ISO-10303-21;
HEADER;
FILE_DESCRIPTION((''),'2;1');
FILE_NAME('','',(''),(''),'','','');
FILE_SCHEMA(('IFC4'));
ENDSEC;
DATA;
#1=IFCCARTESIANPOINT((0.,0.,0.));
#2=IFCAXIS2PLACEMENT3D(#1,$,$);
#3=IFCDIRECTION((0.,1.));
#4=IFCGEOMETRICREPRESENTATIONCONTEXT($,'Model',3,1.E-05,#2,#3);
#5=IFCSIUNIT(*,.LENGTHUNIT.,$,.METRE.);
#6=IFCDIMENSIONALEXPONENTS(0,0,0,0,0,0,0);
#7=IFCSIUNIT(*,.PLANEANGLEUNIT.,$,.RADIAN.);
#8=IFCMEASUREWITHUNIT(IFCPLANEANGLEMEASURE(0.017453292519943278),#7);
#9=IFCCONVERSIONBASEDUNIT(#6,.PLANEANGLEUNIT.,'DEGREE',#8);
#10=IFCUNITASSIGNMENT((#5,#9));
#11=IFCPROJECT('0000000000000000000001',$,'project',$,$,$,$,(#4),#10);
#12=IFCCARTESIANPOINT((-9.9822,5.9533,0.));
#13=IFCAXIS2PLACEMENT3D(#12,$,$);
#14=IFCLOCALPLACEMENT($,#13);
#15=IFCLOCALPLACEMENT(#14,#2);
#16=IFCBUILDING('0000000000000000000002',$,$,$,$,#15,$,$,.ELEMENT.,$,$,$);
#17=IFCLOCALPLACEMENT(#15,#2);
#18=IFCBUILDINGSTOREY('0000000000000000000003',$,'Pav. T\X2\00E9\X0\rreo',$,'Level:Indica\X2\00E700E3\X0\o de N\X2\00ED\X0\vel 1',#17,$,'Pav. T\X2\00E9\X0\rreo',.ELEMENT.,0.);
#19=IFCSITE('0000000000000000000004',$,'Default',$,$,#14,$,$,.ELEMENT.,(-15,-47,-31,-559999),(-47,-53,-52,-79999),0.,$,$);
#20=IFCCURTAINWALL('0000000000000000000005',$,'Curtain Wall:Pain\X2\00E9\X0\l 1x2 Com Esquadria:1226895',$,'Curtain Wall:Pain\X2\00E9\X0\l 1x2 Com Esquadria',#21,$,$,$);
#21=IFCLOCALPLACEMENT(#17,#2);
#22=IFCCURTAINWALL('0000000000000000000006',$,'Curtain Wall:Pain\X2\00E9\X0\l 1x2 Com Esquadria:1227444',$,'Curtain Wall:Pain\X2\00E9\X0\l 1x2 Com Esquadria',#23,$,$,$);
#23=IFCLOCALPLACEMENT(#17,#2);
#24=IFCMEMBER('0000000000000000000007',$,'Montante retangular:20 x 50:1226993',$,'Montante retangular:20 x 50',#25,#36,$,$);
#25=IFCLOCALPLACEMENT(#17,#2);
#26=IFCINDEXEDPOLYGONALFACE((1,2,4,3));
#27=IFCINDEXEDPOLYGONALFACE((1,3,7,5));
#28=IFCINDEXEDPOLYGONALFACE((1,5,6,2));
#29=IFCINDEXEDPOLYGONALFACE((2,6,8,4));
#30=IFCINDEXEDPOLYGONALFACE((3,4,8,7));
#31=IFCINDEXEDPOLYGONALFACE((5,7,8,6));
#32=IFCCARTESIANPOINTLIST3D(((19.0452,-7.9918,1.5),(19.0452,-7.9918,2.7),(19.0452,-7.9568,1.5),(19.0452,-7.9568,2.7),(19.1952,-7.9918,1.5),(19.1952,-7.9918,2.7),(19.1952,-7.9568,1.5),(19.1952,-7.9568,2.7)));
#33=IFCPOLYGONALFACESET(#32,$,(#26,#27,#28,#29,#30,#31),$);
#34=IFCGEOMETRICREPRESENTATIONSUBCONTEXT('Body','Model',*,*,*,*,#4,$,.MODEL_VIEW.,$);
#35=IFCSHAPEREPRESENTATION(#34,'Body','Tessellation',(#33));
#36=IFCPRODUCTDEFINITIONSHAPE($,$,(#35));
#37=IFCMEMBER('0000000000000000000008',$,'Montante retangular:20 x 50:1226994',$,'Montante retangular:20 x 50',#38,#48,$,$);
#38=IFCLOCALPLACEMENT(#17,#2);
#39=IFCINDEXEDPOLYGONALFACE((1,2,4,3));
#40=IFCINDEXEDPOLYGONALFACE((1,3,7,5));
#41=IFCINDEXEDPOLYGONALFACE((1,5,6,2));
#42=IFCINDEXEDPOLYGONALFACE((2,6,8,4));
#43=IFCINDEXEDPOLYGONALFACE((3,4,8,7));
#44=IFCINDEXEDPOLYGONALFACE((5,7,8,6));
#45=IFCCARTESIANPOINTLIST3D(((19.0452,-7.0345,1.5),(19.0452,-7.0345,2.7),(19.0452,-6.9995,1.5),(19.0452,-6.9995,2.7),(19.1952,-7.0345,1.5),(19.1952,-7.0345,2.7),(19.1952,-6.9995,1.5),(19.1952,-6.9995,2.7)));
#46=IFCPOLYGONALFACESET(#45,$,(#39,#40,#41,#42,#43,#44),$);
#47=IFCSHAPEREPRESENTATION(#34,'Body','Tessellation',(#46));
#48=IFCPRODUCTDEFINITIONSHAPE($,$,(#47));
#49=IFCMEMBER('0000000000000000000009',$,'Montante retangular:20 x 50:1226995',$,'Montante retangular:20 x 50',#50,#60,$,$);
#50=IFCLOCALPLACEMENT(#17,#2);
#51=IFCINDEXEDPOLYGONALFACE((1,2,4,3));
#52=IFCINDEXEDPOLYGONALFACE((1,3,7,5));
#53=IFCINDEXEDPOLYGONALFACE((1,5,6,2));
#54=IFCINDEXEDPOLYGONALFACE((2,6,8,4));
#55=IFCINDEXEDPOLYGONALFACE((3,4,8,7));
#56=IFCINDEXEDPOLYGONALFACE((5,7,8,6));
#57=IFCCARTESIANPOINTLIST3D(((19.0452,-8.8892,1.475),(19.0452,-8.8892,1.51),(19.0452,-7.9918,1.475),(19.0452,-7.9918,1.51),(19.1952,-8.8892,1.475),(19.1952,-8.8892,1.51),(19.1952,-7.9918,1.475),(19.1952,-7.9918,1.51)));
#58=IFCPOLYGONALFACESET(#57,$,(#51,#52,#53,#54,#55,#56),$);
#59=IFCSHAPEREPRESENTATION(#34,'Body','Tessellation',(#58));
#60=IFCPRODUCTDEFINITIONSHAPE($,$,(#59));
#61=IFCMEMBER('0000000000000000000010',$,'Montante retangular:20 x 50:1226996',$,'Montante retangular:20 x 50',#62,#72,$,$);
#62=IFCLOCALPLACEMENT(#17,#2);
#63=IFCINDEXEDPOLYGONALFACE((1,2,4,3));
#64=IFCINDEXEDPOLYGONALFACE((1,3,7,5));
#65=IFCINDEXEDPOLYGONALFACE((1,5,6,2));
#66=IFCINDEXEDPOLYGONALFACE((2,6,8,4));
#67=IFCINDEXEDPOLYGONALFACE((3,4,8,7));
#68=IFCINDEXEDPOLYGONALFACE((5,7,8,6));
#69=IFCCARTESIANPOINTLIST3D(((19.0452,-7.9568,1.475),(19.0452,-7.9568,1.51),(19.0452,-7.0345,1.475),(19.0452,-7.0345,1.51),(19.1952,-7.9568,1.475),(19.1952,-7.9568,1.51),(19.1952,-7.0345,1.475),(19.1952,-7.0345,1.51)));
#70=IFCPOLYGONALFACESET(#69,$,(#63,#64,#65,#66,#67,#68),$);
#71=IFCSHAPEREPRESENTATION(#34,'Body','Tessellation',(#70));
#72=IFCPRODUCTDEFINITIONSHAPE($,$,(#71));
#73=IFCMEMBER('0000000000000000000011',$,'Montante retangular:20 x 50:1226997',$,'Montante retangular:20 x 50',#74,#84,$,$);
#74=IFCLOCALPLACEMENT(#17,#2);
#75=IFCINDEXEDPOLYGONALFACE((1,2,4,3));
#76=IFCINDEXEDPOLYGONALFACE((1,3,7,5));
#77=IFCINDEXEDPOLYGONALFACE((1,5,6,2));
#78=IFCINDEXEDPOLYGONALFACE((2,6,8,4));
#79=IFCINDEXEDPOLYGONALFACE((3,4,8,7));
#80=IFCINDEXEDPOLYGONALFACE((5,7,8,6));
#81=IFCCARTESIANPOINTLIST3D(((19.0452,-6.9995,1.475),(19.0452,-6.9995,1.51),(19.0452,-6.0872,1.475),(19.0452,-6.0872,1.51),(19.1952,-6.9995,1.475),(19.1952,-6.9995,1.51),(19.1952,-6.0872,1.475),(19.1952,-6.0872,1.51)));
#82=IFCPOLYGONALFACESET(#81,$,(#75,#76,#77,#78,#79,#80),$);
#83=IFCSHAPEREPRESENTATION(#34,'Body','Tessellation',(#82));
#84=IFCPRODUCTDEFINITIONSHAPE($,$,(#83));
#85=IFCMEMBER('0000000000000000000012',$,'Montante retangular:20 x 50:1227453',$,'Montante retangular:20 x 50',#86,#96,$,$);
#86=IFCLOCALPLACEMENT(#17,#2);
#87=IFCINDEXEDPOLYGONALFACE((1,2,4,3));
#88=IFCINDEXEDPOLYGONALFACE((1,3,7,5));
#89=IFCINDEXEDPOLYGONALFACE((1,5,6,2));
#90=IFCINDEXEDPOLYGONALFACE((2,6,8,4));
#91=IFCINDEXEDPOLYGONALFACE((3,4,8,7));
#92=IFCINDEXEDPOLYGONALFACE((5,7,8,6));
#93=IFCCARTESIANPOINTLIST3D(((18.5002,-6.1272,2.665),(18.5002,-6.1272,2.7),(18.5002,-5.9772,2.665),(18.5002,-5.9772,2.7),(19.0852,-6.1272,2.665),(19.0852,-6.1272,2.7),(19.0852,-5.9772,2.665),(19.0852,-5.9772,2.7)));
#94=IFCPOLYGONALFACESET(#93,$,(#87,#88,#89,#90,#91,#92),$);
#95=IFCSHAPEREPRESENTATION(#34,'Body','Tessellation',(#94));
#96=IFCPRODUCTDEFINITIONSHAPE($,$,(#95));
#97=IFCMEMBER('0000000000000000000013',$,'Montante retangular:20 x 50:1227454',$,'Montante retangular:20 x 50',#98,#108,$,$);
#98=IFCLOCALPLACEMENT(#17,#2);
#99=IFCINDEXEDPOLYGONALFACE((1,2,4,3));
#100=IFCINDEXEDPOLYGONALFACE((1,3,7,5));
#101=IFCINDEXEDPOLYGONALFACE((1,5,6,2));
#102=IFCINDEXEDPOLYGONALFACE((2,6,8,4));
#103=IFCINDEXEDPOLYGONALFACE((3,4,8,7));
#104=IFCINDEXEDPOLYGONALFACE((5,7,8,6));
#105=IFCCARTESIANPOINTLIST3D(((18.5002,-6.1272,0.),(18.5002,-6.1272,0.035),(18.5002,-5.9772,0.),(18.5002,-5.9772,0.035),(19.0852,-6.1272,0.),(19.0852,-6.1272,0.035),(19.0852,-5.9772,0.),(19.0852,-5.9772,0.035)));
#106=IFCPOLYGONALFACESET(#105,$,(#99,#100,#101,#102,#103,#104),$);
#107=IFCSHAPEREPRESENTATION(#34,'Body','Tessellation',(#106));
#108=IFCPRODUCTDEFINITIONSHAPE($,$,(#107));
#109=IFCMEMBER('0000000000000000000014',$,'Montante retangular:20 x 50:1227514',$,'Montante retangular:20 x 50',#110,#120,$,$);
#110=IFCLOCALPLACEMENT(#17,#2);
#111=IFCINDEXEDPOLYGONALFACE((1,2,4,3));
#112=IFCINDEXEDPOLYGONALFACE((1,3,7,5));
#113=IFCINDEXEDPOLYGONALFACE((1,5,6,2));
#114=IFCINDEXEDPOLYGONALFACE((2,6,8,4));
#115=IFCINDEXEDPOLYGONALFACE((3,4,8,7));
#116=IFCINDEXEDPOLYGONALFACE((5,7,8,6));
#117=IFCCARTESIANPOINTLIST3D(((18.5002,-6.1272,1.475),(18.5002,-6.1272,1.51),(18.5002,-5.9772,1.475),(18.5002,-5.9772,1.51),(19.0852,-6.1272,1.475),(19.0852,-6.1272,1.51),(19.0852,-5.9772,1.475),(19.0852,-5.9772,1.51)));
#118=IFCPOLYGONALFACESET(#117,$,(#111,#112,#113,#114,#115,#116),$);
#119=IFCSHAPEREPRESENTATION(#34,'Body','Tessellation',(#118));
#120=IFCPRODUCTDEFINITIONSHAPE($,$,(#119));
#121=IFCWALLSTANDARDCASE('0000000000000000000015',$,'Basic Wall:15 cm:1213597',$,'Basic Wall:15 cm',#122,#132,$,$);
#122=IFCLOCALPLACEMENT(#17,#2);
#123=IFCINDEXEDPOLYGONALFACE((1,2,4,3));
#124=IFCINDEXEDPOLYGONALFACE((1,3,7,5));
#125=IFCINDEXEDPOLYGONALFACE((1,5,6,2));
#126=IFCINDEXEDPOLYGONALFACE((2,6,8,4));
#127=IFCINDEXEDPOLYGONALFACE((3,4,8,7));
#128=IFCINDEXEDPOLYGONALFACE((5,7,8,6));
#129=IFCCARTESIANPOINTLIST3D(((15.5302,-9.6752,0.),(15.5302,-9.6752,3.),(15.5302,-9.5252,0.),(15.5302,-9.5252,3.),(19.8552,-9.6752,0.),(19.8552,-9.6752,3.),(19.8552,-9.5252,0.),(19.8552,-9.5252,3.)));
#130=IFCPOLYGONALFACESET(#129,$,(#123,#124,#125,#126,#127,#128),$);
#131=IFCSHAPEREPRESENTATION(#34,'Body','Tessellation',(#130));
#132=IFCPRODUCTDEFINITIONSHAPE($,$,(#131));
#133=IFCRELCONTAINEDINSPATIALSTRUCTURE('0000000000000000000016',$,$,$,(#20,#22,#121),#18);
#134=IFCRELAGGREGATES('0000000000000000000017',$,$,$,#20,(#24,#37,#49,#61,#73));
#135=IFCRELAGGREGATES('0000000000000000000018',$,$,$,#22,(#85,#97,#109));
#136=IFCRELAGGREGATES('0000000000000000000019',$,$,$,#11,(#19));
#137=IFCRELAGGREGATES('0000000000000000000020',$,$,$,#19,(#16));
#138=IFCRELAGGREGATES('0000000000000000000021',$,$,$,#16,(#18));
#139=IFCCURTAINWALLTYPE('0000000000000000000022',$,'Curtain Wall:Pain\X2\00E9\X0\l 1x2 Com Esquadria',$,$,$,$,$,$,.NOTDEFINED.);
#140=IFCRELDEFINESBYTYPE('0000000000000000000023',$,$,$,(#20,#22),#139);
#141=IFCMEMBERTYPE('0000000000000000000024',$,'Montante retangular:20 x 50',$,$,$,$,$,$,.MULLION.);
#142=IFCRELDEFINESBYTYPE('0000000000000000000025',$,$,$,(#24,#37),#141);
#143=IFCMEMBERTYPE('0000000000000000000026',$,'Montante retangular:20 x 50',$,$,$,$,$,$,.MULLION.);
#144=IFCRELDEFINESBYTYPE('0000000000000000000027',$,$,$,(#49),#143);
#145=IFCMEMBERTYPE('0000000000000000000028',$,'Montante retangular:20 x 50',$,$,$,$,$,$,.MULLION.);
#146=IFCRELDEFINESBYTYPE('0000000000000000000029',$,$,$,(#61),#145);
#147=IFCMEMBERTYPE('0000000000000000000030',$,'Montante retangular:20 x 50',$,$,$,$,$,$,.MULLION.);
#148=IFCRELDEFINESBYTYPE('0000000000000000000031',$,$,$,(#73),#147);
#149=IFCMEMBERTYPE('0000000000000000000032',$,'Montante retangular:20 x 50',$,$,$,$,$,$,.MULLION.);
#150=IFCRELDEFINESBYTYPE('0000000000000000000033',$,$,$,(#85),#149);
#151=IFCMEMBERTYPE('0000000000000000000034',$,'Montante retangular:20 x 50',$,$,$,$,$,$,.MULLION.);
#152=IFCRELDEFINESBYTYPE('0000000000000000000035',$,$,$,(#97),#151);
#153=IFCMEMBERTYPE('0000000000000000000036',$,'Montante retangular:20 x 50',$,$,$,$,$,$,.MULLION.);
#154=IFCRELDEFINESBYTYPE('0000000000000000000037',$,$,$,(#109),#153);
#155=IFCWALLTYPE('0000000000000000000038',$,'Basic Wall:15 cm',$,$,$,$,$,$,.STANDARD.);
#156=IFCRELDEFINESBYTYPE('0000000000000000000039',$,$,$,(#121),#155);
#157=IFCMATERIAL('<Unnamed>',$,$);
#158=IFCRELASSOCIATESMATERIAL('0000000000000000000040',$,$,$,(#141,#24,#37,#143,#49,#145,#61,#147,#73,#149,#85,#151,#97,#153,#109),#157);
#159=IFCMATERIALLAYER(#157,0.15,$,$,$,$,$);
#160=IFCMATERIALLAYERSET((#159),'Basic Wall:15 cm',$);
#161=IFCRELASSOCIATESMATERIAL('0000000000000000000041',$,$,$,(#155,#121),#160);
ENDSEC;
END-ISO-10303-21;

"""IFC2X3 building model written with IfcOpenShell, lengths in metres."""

from ifc_helpers import new_model, entity, si_unit, converted_unit, direction, frame, frame_2d, origin, origin_2d_with_axis, place, context, subcontext, project, spatial, rectangle, extrude, source, transform, mapped, material, layer, layer_set, layer_usage, type_object, type_shapes, element, aggregate, save


model = new_model("IFC2X3")

# Units and contexts
model_context = context("Model", 3, precision=1e-05, world=origin(), true_north=direction((0.0, 1.0)))
body_context = subcontext(model_context, "Body", "Model", "MODEL_VIEW")
ifc_project = project(units=[si_unit("LENGTHUNIT", "METRE"), converted_unit("PLANEANGLEUNIT", "DEGREE", entity("IfcPlaneAngleMeasure", 0.017453292519943278), si_unit("PLANEANGLEUNIT", "RADIAN"), dimensions=[0, 0, 0, 0, 0, 0, 0])], contexts=[model_context])

# Site, building, storey
site_placement = place(None, frame((-9.9822, 5.9533, 0.0)))
site = spatial("IfcSite", under=ifc_project, at=site_placement, Name="Default", CompositionType="ELEMENT", RefLatitude=(-15, -47, -31, -559999), RefLongitude=(-47, -53, -52, -79999), RefElevation=0.0)
building_placement = place(site_placement, origin())
building = spatial("IfcBuilding", under=site, at=building_placement, CompositionType="ELEMENT")
storey_placement = place(building_placement, origin())
storey = spatial("IfcBuildingStorey", under=building, at=storey_placement, Name="Pav. Térreo", ObjectType="Level:Indicação de Nível 1", LongName="Pav. Térreo", CompositionType="ELEMENT", Elevation=0.0)

# Curtain wall
curtain_wall_type = type_object("IfcCurtainWallType", Name="Curtain Wall:Painél 1x2 Com Esquadria", PredefinedType="NOTDEFINED")
curtain_wall_1_placement = place(storey_placement, origin())
curtain_wall_1 = element("IfcCurtainWall", 1, at=curtain_wall_1_placement, inside=storey, type_object=curtain_wall_type, Name="Curtain Wall:Painél 1x2 Com Esquadria:1226895", ObjectType="Curtain Wall:Painél 1x2 Com Esquadria")
ifc_material_1 = material(Name="<Unnamed>")

# Curtain wall
curtain_wall_2_placement = place(storey_placement, origin())
curtain_wall_2 = element("IfcCurtainWall", 2, at=curtain_wall_2_placement, inside=storey, type_object=curtain_wall_type, Name="Curtain Wall:Painél 1x2 Com Esquadria:1227444", ObjectType="Curtain Wall:Painél 1x2 Com Esquadria")

# Members
member_type_1 = type_object("IfcMemberType", Name="Montante retangular:20 x 50", PredefinedType="MULLION", material=ifc_material_1)
shared_shape_1 = source(origin(), body_context, "Body", "SweptSolid", [
    extrude(rectangle(XDim=0.035, YDim=0.15, at=origin_2d_with_axis()), frame((-0.0075, 0.0, -1.2), z_axis=(0.0, 0.0, 1.0), x_axis=(-1.0, 0.0, 0.0)), (0.0, 0.0, 1.0), 1.2),
])
type_shapes(member_type_1, [shared_shape_1])
member_1_placement = place(curtain_wall_1_placement, frame((19.1202, -7.9668, 1.5), z_axis=(0.0, 0.0, -1.0), x_axis=(0.0, 1.0, 0.0)))
member_1 = element("IfcMember", 3, at=member_1_placement, type_object=member_type_1, material=ifc_material_1, Name="Montante retangular:20 x 50:1226993", ObjectType="Montante retangular:20 x 50", context=body_context, shape_type="MappedRepresentation", body=[
    mapped(shared_shape_1, transform((0.0, 0.0, 0.0), scale=1.0)),
])
member_2_placement = place(curtain_wall_1_placement, frame((19.1202, -7.0095, 1.5), z_axis=(0.0, 0.0, -1.0), x_axis=(0.0, 1.0, 0.0)))
member_2 = element("IfcMember", 4, at=member_2_placement, type_object=member_type_1, material=ifc_material_1, Name="Montante retangular:20 x 50:1226994", ObjectType="Montante retangular:20 x 50", context=body_context, shape_type="MappedRepresentation", body=[
    mapped(shared_shape_1, transform((0.0, 0.0, 0.0), scale=1.0)),
])
member_type_2 = type_object("IfcMemberType", Name="Montante retangular:20 x 50", PredefinedType="MULLION", material=ifc_material_1)
shared_shape_2 = source(origin(), body_context, "Body", "SweptSolid", [
    extrude(rectangle(XDim=0.035, YDim=0.15, at=origin_2d_with_axis()), frame((-0.0075, 0.0, -0.8973), z_axis=(0.0, 0.0, 1.0), x_axis=(-1.0, 0.0, 0.0)), (0.0, 0.0, 1.0), 0.8973),
])
type_shapes(member_type_2, [shared_shape_2])
member_3_placement = place(curtain_wall_1_placement, frame((19.1202, -7.9918, 1.5), z_axis=(0.0, 1.0, 0.0), x_axis=(0.0, 0.0, 1.0)))
member_3 = element("IfcMember", 5, at=member_3_placement, type_object=member_type_2, material=ifc_material_1, Name="Montante retangular:20 x 50:1226995", ObjectType="Montante retangular:20 x 50", context=body_context, shape_type="MappedRepresentation", body=[
    mapped(shared_shape_2, transform((0.0, 0.0, 0.0), scale=1.0)),
])
member_type_3 = type_object("IfcMemberType", Name="Montante retangular:20 x 50", PredefinedType="MULLION", material=ifc_material_1)
shared_shape_3 = source(origin(), body_context, "Body", "SweptSolid", [
    extrude(rectangle(XDim=0.035, YDim=0.15, at=origin_2d_with_axis()), frame((-0.0075, 0.0, -0.9223), z_axis=(0.0, 0.0, 1.0), x_axis=(-1.0, 0.0, 0.0)), (0.0, 0.0, 1.0), 0.9223),
])
type_shapes(member_type_3, [shared_shape_3])
member_4_placement = place(curtain_wall_1_placement, frame((19.1202, -7.0345, 1.5), z_axis=(0.0, 1.0, 0.0), x_axis=(0.0, 0.0, 1.0)))
member_4 = element("IfcMember", 6, at=member_4_placement, type_object=member_type_3, material=ifc_material_1, Name="Montante retangular:20 x 50:1226996", ObjectType="Montante retangular:20 x 50", context=body_context, shape_type="MappedRepresentation", body=[
    mapped(shared_shape_3, transform((0.0, 0.0, 0.0), scale=1.0)),
])
member_type_4 = type_object("IfcMemberType", Name="Montante retangular:20 x 50", PredefinedType="MULLION", material=ifc_material_1)
shared_shape_4 = source(origin(), body_context, "Body", "SweptSolid", [
    extrude(rectangle(XDim=0.035, YDim=0.15, at=origin_2d_with_axis()), frame((-0.0075, 0.0, -0.9123), z_axis=(0.0, 0.0, 1.0), x_axis=(-1.0, 0.0, 0.0)), (0.0, 0.0, 1.0), 0.9123),
])
type_shapes(member_type_4, [shared_shape_4])
member_5_placement = place(curtain_wall_1_placement, frame((19.1202, -6.0872, 1.5), z_axis=(0.0, 1.0, 0.0), x_axis=(0.0, 0.0, 1.0)))
member_5 = element("IfcMember", 7, at=member_5_placement, type_object=member_type_4, material=ifc_material_1, Name="Montante retangular:20 x 50:1226997", ObjectType="Montante retangular:20 x 50", context=body_context, shape_type="MappedRepresentation", body=[
    mapped(shared_shape_4, transform((0.0, 0.0, 0.0), scale=1.0)),
])
member_type_5 = type_object("IfcMemberType", Name="Montante retangular:20 x 50", PredefinedType="MULLION", material=ifc_material_1)
shared_shape_5 = source(origin(), body_context, "Body", "SweptSolid", [
    extrude(rectangle(XDim=0.035, YDim=0.15, at=origin_2d_with_axis()), frame((-0.0175, 0.0, -0.585), z_axis=(0.0, 0.0, 1.0), x_axis=(-1.0, 0.0, 0.0)), (0.0, 0.0, 1.0), 0.585),
])
type_shapes(member_type_5, [shared_shape_5])
member_6_placement = place(curtain_wall_2_placement, frame((18.5002, -6.0522, 2.7), z_axis=(-1.0, 0.0, 0.0), x_axis=(0.0, 0.0, 1.0)))
member_6 = element("IfcMember", 8, at=member_6_placement, type_object=member_type_5, material=ifc_material_1, Name="Montante retangular:20 x 50:1227453", ObjectType="Montante retangular:20 x 50", context=body_context, shape_type="MappedRepresentation", body=[
    mapped(shared_shape_5, transform((0.0, 0.0, 0.0), scale=1.0)),
])
member_type_6 = type_object("IfcMemberType", Name="Montante retangular:20 x 50", PredefinedType="MULLION", material=ifc_material_1)
shared_shape_6 = source(origin(), body_context, "Body", "SweptSolid", [
    extrude(rectangle(XDim=0.035, YDim=0.15, at=origin_2d_with_axis()), frame((-0.0175, 0.0, -0.585), z_axis=(0.0, 0.0, 1.0), x_axis=(-1.0, 0.0, 0.0)), (0.0, 0.0, 1.0), 0.585),
])
type_shapes(member_type_6, [shared_shape_6])
member_7_placement = place(curtain_wall_2_placement, frame((19.0852, -6.0522, 0.0), z_axis=(1.0, 0.0, 0.0), x_axis=(0.0, 0.0, -1.0)))
member_7 = element("IfcMember", 9, at=member_7_placement, type_object=member_type_6, material=ifc_material_1, Name="Montante retangular:20 x 50:1227454", ObjectType="Montante retangular:20 x 50", context=body_context, shape_type="MappedRepresentation", body=[
    mapped(shared_shape_6, transform((0.0, 0.0, 0.0), scale=1.0)),
])
member_type_7 = type_object("IfcMemberType", Name="Montante retangular:20 x 50", PredefinedType="MULLION", material=ifc_material_1)
shared_shape_7 = source(origin(), body_context, "Body", "SweptSolid", [
    extrude(rectangle(XDim=0.035, YDim=0.15, at=origin_2d_with_axis()), frame((-0.0075, 0.0, -0.585), z_axis=(0.0, 0.0, 1.0), x_axis=(-1.0, 0.0, 0.0)), (0.0, 0.0, 1.0), 0.585),
])
type_shapes(member_type_7, [shared_shape_7])
member_8_placement = place(curtain_wall_2_placement, frame((18.5002, -6.0522, 1.5), z_axis=(-1.0, 0.0, 0.0), x_axis=(0.0, 0.0, 1.0)))
member_8 = element("IfcMember", 10, at=member_8_placement, type_object=member_type_7, material=ifc_material_1, Name="Montante retangular:20 x 50:1227514", ObjectType="Montante retangular:20 x 50", context=body_context, shape_type="MappedRepresentation", body=[
    mapped(shared_shape_7, transform((0.0, 0.0, 0.0), scale=1.0)),
])

aggregate(curtain_wall_1, [member_1, member_2, member_3, member_4, member_5])
aggregate(curtain_wall_2, [member_6, member_7, member_8])

# Wall
ifc_layer = layer(ifc_material_1, 0.15)
ifc_layer_set = layer_set([ifc_layer], Name="Basic Wall:15 cm")
ifc_layer_usage_1 = layer_usage(ifc_layer_set, "AXIS2", "NEGATIVE", 0.075)
wall_type = type_object("IfcWallType", Name="Basic Wall:15 cm", PredefinedType="STANDARD", material=ifc_layer_set)
wall_1_placement = place(storey_placement, frame((19.8552, -9.6002, 0.0), z_axis=(0.0, 0.0, 1.0), x_axis=(-1.0, 0.0, 0.0)))
element("IfcWallStandardCase", 11, at=wall_1_placement, inside=storey, type_object=wall_type, material=ifc_layer_usage_1, Name="Basic Wall:15 cm:1213597", ObjectType="Basic Wall:15 cm", context=body_context, shape_type="SweptSolid", body=[
    extrude(rectangle(XDim=4.325, YDim=0.15, at=frame_2d((2.1625, 0.0), x_axis=(-1.0, 0.0))), origin(), (0.0, 0.0, 1.0), 3.0),
])

save(model, "model.ifc")
